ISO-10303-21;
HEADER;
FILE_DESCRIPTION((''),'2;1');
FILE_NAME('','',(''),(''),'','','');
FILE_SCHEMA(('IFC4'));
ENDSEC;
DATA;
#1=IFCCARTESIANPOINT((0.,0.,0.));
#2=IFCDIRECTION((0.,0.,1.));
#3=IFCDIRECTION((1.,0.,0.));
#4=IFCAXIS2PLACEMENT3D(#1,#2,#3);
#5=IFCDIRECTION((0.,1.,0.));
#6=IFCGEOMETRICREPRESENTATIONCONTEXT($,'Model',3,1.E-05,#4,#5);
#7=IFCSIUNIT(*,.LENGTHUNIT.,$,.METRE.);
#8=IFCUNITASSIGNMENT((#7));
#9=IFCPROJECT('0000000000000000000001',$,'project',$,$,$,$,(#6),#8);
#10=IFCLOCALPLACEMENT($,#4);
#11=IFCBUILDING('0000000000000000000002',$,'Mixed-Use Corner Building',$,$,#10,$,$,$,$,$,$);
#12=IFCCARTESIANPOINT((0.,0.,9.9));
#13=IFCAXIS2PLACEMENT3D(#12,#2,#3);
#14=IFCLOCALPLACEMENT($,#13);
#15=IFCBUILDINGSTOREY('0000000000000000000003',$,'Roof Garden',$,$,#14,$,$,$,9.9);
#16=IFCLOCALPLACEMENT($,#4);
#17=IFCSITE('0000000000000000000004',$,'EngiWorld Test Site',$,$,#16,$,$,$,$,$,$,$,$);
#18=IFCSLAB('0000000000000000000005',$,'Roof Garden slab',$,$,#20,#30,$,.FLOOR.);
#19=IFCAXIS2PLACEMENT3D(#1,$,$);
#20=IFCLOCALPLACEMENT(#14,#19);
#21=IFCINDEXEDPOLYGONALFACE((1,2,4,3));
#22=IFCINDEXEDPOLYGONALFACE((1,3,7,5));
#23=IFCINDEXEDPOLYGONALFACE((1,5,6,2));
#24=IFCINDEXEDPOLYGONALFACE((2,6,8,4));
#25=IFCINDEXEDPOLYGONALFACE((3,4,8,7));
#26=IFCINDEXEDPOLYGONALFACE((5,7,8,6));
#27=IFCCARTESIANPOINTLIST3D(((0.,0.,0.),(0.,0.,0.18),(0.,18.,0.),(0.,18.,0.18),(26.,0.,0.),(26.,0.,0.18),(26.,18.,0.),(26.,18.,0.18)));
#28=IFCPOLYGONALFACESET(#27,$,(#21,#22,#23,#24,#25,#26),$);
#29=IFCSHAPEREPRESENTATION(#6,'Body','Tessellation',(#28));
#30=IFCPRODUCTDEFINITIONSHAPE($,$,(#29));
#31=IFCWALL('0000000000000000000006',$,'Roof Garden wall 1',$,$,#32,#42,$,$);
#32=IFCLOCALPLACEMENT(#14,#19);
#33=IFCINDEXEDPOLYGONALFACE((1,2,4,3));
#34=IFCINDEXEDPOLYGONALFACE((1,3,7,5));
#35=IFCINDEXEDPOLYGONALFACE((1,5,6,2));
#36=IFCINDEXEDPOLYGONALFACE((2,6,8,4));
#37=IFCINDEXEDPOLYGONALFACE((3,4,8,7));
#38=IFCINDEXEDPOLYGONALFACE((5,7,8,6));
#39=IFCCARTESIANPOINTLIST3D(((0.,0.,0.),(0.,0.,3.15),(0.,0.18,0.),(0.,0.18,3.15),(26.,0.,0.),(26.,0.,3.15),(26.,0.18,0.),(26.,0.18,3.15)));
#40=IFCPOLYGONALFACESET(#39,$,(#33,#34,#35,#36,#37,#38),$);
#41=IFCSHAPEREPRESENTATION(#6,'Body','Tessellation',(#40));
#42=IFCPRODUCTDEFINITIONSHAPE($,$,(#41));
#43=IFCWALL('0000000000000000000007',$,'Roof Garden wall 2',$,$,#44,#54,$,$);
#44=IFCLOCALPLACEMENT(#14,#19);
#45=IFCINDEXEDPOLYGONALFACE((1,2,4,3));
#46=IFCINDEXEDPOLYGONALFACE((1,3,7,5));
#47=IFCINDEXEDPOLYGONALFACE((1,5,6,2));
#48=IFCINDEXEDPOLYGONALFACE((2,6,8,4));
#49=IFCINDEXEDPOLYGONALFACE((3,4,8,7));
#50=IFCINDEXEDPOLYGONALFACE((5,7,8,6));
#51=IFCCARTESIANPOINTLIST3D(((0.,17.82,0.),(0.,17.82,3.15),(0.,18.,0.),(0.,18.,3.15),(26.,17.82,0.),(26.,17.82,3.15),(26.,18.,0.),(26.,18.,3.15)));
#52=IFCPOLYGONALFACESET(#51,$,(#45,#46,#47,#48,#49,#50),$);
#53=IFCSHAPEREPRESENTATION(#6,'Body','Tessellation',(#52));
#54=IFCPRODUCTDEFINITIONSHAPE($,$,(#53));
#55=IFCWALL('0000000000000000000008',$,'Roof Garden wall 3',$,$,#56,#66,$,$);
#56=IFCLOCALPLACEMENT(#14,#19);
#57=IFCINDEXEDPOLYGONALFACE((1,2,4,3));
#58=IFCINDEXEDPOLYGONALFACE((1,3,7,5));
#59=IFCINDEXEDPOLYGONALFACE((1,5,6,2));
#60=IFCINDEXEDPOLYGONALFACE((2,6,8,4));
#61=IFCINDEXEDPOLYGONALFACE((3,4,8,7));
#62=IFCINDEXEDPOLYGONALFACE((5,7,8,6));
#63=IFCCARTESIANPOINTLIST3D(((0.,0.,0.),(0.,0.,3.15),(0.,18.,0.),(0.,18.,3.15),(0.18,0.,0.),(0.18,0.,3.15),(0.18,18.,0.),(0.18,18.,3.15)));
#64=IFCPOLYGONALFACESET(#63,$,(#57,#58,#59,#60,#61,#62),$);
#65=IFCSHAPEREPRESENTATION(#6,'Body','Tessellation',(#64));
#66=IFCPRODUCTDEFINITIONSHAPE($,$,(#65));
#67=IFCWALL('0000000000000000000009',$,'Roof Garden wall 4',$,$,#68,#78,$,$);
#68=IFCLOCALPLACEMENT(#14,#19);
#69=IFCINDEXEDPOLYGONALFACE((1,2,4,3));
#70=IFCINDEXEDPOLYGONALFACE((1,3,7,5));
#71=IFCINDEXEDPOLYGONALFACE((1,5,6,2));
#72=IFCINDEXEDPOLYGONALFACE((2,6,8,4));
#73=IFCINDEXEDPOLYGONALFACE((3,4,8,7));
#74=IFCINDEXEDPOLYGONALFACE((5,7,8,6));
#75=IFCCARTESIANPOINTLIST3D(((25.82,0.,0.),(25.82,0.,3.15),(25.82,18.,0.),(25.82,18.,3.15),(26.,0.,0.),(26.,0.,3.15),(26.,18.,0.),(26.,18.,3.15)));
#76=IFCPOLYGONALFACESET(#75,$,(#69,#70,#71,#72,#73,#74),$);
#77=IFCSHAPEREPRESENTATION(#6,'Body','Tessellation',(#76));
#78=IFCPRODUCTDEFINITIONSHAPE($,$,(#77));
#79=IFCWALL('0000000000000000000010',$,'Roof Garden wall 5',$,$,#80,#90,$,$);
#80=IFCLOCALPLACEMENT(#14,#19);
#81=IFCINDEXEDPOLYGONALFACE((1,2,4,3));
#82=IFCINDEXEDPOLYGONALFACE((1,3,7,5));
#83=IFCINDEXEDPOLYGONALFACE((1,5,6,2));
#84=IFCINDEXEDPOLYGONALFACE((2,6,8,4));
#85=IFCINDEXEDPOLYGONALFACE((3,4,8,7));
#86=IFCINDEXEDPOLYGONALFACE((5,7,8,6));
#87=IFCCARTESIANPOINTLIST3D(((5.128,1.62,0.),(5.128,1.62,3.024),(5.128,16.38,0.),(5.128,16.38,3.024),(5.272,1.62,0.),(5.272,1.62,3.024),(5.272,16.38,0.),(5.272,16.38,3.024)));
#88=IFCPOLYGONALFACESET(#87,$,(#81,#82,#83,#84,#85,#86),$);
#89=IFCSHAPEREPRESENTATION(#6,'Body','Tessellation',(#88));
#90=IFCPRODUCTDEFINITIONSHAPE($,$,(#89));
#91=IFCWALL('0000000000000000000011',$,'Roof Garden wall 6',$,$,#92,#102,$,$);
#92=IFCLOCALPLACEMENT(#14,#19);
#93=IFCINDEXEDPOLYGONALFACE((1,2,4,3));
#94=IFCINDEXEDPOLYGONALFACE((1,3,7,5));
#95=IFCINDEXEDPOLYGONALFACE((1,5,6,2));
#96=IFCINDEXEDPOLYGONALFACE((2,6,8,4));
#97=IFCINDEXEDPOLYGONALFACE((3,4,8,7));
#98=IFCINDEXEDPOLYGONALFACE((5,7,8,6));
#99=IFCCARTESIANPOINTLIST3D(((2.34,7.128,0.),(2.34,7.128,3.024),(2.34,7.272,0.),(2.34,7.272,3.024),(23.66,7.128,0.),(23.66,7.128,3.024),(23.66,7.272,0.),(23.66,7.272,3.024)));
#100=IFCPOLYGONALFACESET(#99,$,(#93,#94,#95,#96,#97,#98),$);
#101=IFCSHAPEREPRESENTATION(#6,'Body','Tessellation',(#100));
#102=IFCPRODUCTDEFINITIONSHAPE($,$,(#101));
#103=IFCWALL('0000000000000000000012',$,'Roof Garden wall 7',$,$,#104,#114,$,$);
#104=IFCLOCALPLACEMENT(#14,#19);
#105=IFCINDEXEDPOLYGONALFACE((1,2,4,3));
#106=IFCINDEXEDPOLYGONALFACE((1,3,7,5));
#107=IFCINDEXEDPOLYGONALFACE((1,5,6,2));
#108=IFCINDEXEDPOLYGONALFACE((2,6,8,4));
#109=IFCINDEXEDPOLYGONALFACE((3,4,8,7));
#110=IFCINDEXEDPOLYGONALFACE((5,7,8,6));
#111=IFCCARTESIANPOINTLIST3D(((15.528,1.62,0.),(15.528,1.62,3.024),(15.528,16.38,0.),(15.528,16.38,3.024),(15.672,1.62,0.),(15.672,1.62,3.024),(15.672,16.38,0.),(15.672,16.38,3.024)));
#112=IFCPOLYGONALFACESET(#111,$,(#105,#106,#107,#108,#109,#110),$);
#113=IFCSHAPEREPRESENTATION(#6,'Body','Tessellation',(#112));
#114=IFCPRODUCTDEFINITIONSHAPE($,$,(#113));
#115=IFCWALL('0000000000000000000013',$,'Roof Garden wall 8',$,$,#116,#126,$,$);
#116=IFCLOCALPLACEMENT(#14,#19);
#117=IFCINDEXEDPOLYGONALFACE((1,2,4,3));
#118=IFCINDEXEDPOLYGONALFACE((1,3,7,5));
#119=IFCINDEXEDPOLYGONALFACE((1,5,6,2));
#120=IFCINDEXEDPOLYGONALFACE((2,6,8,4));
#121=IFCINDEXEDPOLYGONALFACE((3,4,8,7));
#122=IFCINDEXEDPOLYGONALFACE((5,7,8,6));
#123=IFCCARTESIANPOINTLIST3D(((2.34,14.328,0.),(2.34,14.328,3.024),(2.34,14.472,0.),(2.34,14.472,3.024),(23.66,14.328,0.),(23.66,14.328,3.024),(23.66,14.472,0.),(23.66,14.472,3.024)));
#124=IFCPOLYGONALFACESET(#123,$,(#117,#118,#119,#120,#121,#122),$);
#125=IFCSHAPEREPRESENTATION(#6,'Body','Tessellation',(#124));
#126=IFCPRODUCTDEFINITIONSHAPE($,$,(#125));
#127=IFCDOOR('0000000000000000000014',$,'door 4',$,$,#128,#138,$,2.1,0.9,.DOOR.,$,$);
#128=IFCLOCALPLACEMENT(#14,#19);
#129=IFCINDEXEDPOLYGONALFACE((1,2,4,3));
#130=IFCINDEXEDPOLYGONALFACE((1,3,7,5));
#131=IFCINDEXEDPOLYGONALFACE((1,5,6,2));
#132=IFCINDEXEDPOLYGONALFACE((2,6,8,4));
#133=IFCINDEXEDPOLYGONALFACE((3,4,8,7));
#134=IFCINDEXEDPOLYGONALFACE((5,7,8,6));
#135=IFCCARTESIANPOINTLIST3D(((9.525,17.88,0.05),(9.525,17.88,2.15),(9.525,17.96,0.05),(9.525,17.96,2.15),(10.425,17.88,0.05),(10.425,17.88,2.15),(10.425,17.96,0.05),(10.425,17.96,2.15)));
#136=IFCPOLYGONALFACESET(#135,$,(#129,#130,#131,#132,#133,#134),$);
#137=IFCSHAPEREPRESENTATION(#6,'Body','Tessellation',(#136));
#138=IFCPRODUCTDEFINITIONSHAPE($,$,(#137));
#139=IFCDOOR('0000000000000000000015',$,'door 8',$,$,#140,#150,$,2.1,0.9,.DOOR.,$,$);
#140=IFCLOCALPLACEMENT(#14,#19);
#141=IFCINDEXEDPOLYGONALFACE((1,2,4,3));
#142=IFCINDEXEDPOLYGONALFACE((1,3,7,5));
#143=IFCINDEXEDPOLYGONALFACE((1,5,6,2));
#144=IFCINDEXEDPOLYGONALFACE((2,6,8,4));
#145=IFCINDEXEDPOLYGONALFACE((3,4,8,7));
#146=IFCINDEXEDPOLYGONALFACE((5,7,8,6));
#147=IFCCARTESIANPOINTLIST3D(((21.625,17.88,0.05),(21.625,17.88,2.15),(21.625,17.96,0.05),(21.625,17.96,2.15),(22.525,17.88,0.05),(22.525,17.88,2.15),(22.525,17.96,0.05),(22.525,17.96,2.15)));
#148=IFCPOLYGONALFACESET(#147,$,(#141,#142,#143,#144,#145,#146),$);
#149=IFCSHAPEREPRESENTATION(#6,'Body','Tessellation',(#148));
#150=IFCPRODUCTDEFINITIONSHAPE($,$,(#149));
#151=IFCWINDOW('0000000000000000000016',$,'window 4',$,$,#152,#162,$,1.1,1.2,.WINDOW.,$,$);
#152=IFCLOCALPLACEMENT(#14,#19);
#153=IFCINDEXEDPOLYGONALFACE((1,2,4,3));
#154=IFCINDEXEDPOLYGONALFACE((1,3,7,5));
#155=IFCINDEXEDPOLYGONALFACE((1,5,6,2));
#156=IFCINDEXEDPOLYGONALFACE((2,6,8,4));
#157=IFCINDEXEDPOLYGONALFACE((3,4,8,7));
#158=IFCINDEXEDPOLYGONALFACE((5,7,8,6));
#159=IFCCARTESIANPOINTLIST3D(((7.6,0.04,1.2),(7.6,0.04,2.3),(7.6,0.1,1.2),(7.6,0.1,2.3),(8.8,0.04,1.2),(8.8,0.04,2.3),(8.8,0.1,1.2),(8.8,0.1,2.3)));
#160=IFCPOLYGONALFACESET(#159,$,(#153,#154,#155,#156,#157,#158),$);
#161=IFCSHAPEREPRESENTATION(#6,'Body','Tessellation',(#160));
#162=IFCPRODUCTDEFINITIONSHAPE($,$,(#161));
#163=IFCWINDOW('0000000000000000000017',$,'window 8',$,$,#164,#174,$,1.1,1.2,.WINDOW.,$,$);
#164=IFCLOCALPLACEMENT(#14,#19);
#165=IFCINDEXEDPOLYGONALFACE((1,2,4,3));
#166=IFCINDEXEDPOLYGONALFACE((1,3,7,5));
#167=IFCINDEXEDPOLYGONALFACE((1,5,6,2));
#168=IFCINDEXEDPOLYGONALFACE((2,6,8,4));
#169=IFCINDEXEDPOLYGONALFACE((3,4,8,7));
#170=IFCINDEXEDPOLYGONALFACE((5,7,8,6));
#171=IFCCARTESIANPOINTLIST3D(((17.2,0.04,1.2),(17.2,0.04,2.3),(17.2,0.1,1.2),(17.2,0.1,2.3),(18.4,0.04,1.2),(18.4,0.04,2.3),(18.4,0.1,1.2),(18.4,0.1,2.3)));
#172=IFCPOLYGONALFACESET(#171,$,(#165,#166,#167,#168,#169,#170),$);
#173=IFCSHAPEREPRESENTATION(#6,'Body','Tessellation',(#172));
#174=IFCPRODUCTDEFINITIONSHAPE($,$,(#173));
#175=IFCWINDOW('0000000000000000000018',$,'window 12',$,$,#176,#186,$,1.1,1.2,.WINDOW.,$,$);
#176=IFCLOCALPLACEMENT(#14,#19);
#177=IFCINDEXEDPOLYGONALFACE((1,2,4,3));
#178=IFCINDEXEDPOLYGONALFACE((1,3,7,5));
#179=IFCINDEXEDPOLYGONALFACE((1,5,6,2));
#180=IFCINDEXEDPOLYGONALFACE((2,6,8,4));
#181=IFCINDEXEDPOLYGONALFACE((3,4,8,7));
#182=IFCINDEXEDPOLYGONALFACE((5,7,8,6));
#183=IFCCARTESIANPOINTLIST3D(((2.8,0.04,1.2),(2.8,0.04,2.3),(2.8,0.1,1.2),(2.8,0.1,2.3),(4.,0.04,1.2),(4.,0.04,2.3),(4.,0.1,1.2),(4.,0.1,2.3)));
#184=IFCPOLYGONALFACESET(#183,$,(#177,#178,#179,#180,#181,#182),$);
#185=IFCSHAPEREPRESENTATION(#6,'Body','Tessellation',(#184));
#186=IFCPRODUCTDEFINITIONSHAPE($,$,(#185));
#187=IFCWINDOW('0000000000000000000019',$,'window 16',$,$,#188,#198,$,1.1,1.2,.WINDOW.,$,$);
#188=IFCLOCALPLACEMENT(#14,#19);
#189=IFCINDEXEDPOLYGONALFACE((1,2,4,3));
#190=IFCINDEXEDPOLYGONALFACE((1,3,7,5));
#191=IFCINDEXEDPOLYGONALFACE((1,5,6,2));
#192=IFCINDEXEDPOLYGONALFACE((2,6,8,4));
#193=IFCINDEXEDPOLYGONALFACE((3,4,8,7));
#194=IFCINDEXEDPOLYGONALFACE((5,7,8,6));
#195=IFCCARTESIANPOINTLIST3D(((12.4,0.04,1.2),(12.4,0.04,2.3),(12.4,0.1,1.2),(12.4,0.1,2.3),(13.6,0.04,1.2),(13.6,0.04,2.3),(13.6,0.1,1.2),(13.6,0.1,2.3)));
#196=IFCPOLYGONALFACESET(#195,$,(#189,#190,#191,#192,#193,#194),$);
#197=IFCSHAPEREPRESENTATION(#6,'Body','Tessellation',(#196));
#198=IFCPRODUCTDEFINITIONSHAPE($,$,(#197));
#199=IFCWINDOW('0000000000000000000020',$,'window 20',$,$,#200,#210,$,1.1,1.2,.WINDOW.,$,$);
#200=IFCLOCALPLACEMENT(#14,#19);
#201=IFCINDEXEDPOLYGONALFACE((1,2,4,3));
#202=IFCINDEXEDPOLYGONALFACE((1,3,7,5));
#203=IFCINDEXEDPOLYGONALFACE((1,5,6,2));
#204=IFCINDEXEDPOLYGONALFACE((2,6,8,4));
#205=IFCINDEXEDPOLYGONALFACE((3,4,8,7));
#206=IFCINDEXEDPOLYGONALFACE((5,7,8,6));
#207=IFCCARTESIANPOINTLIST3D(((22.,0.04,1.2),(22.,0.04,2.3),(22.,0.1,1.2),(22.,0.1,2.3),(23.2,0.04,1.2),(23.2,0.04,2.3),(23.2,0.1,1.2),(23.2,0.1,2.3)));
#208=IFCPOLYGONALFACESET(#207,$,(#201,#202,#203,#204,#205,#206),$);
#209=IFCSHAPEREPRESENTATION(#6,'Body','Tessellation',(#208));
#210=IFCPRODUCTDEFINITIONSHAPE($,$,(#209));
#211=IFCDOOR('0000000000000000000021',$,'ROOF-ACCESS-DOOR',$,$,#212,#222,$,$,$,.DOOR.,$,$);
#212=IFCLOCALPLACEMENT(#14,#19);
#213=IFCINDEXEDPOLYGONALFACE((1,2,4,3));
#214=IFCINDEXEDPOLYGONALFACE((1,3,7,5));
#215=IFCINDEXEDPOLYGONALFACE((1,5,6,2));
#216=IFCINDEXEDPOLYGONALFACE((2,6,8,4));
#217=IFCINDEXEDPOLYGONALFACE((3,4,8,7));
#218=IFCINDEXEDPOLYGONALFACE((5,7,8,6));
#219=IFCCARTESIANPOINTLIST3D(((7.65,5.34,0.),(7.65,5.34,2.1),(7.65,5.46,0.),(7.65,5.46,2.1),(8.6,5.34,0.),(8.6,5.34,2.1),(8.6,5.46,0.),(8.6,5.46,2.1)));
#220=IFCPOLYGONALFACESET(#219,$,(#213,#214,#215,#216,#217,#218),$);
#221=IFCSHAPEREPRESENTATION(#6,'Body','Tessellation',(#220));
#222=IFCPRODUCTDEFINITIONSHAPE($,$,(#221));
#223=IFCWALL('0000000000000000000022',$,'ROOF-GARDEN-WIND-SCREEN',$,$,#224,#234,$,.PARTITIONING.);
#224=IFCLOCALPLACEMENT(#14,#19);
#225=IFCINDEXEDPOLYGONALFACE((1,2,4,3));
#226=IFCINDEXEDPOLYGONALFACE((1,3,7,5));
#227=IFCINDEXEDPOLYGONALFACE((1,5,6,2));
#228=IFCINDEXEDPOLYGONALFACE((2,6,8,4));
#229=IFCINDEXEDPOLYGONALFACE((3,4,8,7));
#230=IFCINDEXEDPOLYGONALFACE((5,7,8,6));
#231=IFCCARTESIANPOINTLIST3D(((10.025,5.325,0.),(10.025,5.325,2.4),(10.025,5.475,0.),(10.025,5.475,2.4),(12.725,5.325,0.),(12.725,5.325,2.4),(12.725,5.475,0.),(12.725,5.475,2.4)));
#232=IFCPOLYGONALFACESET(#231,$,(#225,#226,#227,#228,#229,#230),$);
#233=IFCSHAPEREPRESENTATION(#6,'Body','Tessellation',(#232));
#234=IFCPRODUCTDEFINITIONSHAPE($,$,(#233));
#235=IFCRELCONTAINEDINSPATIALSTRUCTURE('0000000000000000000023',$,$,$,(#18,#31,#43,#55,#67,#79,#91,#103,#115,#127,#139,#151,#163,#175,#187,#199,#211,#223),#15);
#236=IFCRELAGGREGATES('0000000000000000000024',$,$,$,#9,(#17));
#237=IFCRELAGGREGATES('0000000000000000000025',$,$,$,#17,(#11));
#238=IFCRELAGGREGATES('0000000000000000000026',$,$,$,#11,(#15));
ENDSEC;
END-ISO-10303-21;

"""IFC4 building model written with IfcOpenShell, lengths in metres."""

from ifc_helpers import new_model, si_unit, direction, frame, origin, origin_with_axes, origin_2d, origin_2d_with_axis, place, context, project, spatial, rectangle, extrude, element, save


model = new_model("IFC4")

# Units and contexts
model_context = context("Model", 3, precision=1e-05, world=origin_with_axes(), true_north=direction((0.0, 1.0, 0.0)))
ifc_project = project(units=[si_unit("LENGTHUNIT", "METRE")], contexts=[model_context])

# Site, building, storey
site_placement = place(None, origin_with_axes())
site = spatial("IfcSite", under=ifc_project, at=site_placement, Name="EngiWorld Test Site")
building_placement = place(None, origin_with_axes())
building = spatial("IfcBuilding", under=site, at=building_placement, Name="Mixed-Use Corner Building")
storey_placement = place(None, frame((0.0, 0.0, 9.9), z_axis=(0.0, 0.0, 1.0), x_axis=(1.0, 0.0, 0.0)))
storey = spatial("IfcBuildingStorey", under=building, at=storey_placement, Name="Roof Garden", Elevation=9.9)

# Slab
slab_placement = place(None, frame((13.0, 9.0, 9.9), z_axis=(0.0, 0.0, 1.0), x_axis=(1.0, 0.0, 0.0)))
element("IfcSlab", 1, at=slab_placement, inside=storey, Name="Roof Garden slab", PredefinedType="FLOOR", context=model_context, shape_type="SweptSolid", body=[
    extrude(rectangle(XDim=26.0, YDim=18.0, at=origin_2d_with_axis()), origin_with_axes(), (0.0, 0.0, 1.0), 0.18),
])

# Walls
for number, where, z_axis, x_axis, name in (
    (2, (13.0, 0.09, 9.9), (0.0, 0.0, 1.0), (1.0, 0.0, 0.0), "Roof Garden wall 1"),
    (3, (13.0, 17.91, 9.9), (0.0, 0.0, 1.0), (1.0, 0.0, 0.0), "Roof Garden wall 2"),
):
    element("IfcWall", number, at=place(None, frame(where, z_axis=z_axis, x_axis=x_axis)), inside=storey, Name=name, context=model_context, shape_type="SweptSolid", body=[
        extrude(rectangle(XDim=26.0, YDim=0.18, at=origin_2d_with_axis()), origin_with_axes(), (0.0, 0.0, 1.0), 3.15),
    ])
for number, where, z_axis, x_axis, name in (
    (4, (0.09, 9.0, 9.9), (0.0, 0.0, 1.0), (1.0, 0.0, 0.0), "Roof Garden wall 3"),
    (5, (25.91, 9.0, 9.9), (0.0, 0.0, 1.0), (1.0, 0.0, 0.0), "Roof Garden wall 4"),
):
    element("IfcWall", number, at=place(None, frame(where, z_axis=z_axis, x_axis=x_axis)), inside=storey, Name=name, context=model_context, shape_type="SweptSolid", body=[
        extrude(rectangle(XDim=0.18, YDim=18.0, at=origin_2d_with_axis()), origin_with_axes(), (0.0, 0.0, 1.0), 3.15),
    ])
wall_1_placement = place(None, frame((5.2, 9.0, 9.9), z_axis=(0.0, 0.0, 1.0), x_axis=(1.0, 0.0, 0.0)))
element("IfcWall", 6, at=wall_1_placement, inside=storey, Name="Roof Garden wall 5", context=model_context, shape_type="SweptSolid", body=[
    extrude(rectangle(XDim=0.144, YDim=14.76, at=origin_2d_with_axis()), origin_with_axes(), (0.0, 0.0, 1.0), 3.024),
])
wall_2_placement = place(None, frame((13.0, 7.2, 9.9), z_axis=(0.0, 0.0, 1.0), x_axis=(1.0, 0.0, 0.0)))
element("IfcWall", 7, at=wall_2_placement, inside=storey, Name="Roof Garden wall 6", context=model_context, shape_type="SweptSolid", body=[
    extrude(rectangle(XDim=21.32, YDim=0.144, at=origin_2d_with_axis()), origin_with_axes(), (0.0, 0.0, 1.0), 3.024),
])
wall_3_placement = place(None, frame((15.6, 9.0, 9.9), z_axis=(0.0, 0.0, 1.0), x_axis=(1.0, 0.0, 0.0)))
element("IfcWall", 8, at=wall_3_placement, inside=storey, Name="Roof Garden wall 7", context=model_context, shape_type="SweptSolid", body=[
    extrude(rectangle(XDim=0.144, YDim=14.76, at=origin_2d_with_axis()), origin_with_axes(), (0.0, 0.0, 1.0), 3.024),
])
wall_4_placement = place(None, frame((13.0, 14.4, 9.9), z_axis=(0.0, 0.0, 1.0), x_axis=(1.0, 0.0, 0.0)))
element("IfcWall", 9, at=wall_4_placement, inside=storey, Name="Roof Garden wall 8", context=model_context, shape_type="SweptSolid", body=[
    extrude(rectangle(XDim=21.32, YDim=0.144, at=origin_2d_with_axis()), origin_with_axes(), (0.0, 0.0, 1.0), 3.024),
])

# Doors
for number, where, z_axis, x_axis, name in (
    (10, (9.975, 17.92, 9.95), (0.0, 0.0, 1.0), (1.0, 0.0, 0.0), "door 4"),
    (11, (22.075, 17.92, 9.95), (0.0, 0.0, 1.0), (1.0, 0.0, 0.0), "door 8"),
):
    element("IfcDoor", number, at=place(None, frame(where, z_axis=z_axis, x_axis=x_axis)), inside=storey, Name=name, OverallHeight=2.1, OverallWidth=0.9, PredefinedType="DOOR", context=model_context, shape_type="SweptSolid", body=[
        extrude(rectangle(XDim=0.9, YDim=0.08, at=origin_2d_with_axis()), origin_with_axes(), (0.0, 0.0, 1.0), 2.1),
    ])

# Windows
for number, where, z_axis, x_axis, name in (
    (12, (8.2, 0.07, 11.1), (0.0, 0.0, 1.0), (1.0, 0.0, 0.0), "window 4"),
    (13, (17.8, 0.07, 11.1), (0.0, 0.0, 1.0), (1.0, 0.0, 0.0), "window 8"),
    (14, (3.4, 0.07, 11.1), (0.0, 0.0, 1.0), (1.0, 0.0, 0.0), "window 12"),
    (15, (13.0, 0.07, 11.1), (0.0, 0.0, 1.0), (1.0, 0.0, 0.0), "window 16"),
    (16, (22.6, 0.07, 11.1), (0.0, 0.0, 1.0), (1.0, 0.0, 0.0), "window 20"),
):
    element("IfcWindow", number, at=place(None, frame(where, z_axis=z_axis, x_axis=x_axis)), inside=storey, Name=name, OverallHeight=1.1, OverallWidth=1.2, PredefinedType="WINDOW", context=model_context, shape_type="SweptSolid", body=[
        extrude(rectangle(XDim=1.2, YDim=0.06, at=origin_2d_with_axis()), origin_with_axes(), (0.0, 0.0, 1.0), 1.1),
    ])

# Door
door_placement = place(None, frame((8.125, 5.4, 9.9)))
element("IfcDoor", 17, at=door_placement, inside=storey, Name="ROOF-ACCESS-DOOR", PredefinedType="DOOR", context=model_context, shape_type="SweptSolid", body=[
    extrude(rectangle(XDim=0.95, YDim=0.12, at=origin_2d()), origin(), (0.0, 0.0, 1.0), 2.1),
])

# Wall
wall_5_placement = place(None, frame((11.375, 5.4, 9.9)))
element("IfcWall", 18, at=wall_5_placement, inside=storey, Name="ROOF-GARDEN-WIND-SCREEN", PredefinedType="PARTITIONING", context=model_context, shape_type="SweptSolid", body=[
    extrude(rectangle(XDim=2.7, YDim=0.15, at=origin_2d()), origin(), (0.0, 0.0, 1.0), 2.4),
])

save(model, "model.ifc")
